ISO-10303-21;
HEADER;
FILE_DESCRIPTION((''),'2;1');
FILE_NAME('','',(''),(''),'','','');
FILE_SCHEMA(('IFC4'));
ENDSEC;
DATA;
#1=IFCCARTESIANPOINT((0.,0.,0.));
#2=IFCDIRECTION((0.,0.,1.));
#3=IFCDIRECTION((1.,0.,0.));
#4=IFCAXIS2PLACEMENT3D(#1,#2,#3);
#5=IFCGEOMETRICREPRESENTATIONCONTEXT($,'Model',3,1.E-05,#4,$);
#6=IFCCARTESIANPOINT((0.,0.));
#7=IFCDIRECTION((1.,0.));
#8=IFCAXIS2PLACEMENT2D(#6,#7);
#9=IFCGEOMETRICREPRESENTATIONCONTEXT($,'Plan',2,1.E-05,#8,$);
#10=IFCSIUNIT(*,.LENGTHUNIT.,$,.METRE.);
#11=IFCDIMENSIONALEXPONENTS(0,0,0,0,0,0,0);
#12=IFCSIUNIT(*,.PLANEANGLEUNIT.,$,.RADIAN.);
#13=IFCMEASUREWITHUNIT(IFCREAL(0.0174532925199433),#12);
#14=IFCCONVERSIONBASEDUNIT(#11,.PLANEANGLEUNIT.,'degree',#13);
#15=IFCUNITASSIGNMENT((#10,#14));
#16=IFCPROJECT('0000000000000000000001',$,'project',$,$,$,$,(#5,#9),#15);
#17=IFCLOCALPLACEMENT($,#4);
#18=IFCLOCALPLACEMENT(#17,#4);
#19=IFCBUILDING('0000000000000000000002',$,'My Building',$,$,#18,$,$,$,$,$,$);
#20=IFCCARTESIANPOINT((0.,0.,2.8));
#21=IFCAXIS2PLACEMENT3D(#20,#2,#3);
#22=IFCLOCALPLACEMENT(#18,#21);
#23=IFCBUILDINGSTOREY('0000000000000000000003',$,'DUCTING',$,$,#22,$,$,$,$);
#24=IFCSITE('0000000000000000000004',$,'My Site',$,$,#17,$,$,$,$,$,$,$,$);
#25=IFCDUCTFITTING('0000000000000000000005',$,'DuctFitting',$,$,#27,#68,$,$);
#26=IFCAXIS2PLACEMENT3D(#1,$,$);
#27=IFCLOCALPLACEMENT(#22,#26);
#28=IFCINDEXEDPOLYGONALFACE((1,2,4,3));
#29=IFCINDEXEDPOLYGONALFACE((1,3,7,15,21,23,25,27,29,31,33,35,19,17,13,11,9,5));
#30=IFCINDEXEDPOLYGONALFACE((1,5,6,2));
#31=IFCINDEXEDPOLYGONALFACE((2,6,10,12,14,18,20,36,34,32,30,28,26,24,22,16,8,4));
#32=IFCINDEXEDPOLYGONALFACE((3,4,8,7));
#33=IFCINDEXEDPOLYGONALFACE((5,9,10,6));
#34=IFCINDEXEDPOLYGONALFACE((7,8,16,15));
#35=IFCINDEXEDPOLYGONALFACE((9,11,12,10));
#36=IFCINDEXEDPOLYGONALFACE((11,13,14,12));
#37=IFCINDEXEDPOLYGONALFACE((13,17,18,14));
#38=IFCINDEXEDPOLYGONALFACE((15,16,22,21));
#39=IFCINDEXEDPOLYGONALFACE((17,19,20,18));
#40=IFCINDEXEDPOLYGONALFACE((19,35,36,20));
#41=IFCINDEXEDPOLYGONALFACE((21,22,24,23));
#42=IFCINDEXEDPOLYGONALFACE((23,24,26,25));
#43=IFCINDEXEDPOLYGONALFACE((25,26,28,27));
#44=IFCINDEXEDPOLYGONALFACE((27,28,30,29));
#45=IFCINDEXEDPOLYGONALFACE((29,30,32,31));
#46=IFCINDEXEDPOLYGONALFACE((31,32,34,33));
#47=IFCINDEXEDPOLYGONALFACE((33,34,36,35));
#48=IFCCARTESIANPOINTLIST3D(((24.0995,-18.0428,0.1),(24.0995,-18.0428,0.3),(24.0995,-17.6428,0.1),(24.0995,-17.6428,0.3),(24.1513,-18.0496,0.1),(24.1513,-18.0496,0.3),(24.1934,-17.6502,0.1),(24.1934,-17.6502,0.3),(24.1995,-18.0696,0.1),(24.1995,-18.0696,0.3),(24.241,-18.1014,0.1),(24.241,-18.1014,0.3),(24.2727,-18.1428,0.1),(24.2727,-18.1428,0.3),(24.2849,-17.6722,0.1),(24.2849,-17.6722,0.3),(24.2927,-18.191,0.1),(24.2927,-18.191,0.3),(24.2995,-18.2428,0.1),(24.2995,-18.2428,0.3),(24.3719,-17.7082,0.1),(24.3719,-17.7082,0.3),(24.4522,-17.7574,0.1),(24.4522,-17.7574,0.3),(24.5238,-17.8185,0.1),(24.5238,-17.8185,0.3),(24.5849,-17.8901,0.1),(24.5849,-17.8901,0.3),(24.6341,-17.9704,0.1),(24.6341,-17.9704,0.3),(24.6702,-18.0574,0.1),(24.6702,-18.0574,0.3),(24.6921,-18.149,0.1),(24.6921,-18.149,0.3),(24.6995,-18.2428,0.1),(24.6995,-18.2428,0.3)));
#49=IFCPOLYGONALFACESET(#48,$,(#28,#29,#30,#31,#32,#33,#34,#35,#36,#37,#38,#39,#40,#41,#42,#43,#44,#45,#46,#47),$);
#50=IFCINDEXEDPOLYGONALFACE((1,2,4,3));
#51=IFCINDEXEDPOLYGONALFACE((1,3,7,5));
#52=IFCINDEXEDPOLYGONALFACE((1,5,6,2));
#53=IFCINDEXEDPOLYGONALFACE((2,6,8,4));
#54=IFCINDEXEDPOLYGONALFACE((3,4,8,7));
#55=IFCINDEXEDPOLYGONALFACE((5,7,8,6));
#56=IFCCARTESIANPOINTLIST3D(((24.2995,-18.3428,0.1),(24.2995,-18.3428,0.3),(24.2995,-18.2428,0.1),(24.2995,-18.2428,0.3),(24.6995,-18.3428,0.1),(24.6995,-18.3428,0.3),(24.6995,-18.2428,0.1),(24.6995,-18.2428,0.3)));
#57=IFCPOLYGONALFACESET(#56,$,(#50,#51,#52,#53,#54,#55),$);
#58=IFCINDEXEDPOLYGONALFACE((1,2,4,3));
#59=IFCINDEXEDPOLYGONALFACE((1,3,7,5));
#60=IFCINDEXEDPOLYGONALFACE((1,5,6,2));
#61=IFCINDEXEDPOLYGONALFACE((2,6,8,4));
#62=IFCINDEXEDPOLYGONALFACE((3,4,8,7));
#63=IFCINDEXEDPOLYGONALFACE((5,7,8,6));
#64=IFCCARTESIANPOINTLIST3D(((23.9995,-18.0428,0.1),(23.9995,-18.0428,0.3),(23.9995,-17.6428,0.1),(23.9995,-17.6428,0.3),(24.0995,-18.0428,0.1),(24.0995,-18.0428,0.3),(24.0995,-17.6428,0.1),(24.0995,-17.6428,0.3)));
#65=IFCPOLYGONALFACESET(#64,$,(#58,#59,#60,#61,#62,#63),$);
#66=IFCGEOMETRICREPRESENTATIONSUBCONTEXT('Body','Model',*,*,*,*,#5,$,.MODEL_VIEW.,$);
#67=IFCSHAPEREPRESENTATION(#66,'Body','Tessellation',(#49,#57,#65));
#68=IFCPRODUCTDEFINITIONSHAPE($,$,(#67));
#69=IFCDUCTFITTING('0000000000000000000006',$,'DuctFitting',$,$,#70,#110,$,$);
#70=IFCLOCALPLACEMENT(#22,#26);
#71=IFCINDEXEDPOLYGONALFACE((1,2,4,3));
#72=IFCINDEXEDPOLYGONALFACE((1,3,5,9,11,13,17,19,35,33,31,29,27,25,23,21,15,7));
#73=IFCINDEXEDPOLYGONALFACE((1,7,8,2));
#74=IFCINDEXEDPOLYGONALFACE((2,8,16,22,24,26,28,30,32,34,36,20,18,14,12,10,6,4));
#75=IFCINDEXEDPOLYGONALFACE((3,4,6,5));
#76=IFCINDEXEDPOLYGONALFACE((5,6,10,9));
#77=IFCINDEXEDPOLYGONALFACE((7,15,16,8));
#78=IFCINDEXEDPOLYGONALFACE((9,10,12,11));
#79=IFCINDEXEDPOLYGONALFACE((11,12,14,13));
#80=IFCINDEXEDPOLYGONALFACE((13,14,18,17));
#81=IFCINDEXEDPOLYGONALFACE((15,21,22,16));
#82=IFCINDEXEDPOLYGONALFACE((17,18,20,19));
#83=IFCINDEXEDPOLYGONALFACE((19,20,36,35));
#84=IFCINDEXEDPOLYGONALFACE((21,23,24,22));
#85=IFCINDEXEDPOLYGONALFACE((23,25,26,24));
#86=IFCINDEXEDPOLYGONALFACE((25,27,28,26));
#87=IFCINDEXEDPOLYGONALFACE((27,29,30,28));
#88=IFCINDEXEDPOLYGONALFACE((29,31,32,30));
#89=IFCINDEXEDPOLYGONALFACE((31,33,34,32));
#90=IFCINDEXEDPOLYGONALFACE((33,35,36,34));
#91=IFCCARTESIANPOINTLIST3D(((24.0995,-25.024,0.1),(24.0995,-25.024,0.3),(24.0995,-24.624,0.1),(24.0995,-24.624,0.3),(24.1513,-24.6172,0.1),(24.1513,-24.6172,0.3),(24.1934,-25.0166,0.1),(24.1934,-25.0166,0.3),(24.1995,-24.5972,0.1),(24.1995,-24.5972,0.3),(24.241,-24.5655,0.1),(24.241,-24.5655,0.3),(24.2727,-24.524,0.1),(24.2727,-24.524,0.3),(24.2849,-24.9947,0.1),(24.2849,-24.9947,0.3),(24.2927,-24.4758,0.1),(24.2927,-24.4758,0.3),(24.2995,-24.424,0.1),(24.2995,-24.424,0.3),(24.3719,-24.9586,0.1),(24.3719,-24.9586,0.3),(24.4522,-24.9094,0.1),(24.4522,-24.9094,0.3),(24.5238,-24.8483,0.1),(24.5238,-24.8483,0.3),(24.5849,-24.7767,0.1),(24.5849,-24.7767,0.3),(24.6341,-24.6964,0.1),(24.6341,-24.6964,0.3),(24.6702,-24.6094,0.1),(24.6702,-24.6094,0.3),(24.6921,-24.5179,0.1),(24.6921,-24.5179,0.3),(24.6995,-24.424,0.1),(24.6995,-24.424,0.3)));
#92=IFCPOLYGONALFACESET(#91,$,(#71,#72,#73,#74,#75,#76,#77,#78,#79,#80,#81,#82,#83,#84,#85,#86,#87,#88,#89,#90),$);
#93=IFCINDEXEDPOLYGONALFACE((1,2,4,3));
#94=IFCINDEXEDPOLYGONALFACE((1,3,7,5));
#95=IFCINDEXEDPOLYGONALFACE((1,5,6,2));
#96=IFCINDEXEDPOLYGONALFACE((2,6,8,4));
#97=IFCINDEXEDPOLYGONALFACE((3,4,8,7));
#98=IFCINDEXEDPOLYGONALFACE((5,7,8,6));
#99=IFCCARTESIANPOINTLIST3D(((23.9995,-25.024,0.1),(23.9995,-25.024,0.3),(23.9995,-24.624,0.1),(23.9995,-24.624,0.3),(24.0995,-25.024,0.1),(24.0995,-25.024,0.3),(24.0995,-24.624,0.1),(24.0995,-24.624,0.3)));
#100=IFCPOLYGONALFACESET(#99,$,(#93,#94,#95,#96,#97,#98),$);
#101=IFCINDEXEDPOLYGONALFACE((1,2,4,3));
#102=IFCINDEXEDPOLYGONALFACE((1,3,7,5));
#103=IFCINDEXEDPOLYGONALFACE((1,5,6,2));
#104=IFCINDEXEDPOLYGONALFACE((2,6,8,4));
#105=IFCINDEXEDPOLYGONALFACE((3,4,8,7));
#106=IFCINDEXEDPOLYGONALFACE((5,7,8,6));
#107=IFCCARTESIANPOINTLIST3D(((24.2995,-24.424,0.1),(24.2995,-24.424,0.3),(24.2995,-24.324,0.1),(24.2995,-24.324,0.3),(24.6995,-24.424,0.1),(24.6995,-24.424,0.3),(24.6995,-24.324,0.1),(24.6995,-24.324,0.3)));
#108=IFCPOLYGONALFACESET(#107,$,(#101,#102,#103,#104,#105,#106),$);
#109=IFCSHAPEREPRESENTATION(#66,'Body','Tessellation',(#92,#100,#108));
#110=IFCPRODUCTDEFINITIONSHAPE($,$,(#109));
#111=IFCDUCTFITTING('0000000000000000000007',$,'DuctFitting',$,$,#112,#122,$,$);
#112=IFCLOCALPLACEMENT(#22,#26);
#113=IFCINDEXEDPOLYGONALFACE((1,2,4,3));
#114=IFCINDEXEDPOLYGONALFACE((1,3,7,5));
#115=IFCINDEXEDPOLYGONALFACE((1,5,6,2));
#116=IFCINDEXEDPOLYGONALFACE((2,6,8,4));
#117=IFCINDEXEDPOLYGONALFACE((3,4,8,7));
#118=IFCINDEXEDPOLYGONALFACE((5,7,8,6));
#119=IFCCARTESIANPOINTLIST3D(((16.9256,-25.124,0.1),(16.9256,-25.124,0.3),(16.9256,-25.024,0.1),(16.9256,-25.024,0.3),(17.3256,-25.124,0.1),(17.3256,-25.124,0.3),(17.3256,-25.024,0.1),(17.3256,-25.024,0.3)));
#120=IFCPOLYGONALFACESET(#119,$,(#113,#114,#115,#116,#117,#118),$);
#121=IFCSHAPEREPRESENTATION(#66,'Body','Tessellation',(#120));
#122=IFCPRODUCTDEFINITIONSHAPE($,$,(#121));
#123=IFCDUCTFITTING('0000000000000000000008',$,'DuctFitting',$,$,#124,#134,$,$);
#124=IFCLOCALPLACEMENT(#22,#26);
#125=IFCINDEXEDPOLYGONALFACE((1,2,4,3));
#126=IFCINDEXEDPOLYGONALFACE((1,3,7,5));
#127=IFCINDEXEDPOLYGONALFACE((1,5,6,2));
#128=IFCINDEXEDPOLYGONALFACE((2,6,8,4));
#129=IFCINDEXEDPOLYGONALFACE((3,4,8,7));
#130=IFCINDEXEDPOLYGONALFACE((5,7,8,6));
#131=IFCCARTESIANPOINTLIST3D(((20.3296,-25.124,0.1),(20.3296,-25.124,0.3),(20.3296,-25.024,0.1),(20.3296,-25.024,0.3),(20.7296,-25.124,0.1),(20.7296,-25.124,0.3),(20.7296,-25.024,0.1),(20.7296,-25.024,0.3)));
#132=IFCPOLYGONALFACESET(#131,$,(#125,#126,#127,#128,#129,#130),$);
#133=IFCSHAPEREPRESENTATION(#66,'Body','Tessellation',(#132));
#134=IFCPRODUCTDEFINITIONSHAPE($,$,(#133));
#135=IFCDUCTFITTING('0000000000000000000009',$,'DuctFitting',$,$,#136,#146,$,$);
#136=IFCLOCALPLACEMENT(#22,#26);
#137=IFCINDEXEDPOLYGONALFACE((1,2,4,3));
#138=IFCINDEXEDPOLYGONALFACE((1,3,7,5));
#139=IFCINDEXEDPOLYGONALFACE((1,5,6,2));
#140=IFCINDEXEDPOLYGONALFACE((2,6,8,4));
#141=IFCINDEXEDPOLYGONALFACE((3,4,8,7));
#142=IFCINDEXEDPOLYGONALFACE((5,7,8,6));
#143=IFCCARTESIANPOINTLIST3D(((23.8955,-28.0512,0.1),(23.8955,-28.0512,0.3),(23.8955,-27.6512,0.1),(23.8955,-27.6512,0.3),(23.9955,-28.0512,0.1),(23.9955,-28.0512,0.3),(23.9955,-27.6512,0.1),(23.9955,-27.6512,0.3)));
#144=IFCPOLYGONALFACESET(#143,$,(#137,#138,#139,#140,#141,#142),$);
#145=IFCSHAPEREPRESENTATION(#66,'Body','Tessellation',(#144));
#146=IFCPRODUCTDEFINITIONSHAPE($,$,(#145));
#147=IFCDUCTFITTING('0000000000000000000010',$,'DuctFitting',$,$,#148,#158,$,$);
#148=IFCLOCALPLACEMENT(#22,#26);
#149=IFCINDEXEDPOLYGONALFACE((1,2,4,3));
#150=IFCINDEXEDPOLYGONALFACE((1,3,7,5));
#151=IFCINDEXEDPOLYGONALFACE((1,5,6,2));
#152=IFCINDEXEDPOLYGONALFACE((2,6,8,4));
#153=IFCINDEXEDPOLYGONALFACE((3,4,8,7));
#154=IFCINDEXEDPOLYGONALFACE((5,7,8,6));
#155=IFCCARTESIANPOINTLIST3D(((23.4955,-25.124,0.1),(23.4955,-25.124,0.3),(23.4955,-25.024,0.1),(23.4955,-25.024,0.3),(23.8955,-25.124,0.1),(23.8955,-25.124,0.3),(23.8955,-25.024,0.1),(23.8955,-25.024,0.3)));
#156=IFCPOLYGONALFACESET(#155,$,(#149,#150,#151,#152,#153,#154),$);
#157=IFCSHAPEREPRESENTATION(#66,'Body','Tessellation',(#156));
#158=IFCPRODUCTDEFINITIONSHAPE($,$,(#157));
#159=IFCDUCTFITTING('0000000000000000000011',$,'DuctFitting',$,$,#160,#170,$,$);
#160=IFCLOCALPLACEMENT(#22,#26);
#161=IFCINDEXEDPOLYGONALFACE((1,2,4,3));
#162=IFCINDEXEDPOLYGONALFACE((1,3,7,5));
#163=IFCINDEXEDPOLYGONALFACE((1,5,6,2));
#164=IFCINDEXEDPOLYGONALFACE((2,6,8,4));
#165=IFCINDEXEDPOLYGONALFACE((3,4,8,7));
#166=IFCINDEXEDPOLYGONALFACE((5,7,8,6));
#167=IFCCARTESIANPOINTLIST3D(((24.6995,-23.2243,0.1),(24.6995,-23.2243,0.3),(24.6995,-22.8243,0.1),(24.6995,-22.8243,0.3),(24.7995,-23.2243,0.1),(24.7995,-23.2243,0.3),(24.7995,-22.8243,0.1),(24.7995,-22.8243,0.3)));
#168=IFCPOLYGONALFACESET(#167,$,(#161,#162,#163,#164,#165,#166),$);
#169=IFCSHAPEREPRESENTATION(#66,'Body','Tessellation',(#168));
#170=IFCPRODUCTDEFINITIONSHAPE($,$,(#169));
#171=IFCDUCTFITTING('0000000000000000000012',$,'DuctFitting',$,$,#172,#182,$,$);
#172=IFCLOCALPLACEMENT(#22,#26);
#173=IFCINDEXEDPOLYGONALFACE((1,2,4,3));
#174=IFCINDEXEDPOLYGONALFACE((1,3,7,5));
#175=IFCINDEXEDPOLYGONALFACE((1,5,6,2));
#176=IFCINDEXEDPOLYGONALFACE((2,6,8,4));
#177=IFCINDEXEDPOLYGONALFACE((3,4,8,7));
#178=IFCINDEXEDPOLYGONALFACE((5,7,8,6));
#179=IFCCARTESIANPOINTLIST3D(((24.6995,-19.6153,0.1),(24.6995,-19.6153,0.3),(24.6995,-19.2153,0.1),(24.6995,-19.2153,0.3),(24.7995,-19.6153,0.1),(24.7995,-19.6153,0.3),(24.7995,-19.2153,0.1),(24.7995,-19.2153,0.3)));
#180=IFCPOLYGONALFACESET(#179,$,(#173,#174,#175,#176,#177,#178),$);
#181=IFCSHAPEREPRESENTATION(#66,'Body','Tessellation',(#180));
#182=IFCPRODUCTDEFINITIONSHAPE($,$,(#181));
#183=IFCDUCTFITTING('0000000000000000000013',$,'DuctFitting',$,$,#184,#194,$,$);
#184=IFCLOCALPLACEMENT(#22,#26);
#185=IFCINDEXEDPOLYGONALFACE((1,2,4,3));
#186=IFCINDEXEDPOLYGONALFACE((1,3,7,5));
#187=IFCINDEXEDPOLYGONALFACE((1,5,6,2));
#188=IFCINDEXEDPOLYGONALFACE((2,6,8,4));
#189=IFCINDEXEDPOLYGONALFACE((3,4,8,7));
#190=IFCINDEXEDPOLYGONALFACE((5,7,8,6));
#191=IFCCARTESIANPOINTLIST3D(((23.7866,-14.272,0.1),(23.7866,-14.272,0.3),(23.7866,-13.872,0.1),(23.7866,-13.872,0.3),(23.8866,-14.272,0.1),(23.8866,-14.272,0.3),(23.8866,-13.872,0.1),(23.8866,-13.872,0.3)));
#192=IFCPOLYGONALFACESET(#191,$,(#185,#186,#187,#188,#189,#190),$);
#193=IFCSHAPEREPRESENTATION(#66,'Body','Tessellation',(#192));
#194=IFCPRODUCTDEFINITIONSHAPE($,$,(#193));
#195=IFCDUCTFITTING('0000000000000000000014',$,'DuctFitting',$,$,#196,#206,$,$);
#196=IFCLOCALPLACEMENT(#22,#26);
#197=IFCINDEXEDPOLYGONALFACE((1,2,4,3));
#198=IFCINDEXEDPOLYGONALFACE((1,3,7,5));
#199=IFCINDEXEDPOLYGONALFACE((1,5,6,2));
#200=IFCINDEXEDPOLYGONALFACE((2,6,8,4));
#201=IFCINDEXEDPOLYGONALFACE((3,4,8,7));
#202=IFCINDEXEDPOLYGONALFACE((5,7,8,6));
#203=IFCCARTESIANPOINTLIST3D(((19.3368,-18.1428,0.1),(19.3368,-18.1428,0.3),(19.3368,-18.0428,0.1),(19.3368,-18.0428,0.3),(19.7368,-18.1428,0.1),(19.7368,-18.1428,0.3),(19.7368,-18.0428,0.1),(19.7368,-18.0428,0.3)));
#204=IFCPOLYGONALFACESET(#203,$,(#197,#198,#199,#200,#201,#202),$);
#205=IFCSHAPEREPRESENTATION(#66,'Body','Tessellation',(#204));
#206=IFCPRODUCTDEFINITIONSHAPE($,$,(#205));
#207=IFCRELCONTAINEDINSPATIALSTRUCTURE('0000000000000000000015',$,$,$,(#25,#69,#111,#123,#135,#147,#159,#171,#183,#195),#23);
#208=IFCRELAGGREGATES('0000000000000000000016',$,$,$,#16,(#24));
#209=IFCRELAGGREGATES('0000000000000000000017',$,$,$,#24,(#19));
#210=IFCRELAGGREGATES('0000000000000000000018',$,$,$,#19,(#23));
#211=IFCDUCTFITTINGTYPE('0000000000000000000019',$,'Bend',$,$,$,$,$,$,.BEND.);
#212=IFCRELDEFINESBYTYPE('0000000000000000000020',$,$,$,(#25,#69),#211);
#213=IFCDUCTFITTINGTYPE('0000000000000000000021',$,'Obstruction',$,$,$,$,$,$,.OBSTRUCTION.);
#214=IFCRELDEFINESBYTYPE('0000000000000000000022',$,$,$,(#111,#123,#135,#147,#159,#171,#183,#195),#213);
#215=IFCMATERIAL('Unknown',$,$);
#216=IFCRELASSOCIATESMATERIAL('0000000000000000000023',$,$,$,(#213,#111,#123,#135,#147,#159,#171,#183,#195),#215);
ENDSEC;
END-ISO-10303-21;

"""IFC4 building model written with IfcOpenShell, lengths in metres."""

from ifc_helpers import new_model, entity, si_unit, converted_unit, frame, origin_with_axes, origin_2d_with_axis, place, context, subcontext, project, spatial, line, arc, indexed_curve, rectangle, outline, extrude, source, transform, mapped, material, material_profile, profile_set, profile_usage, type_object, type_shapes, element, save


model = new_model("IFC4")

# Units and contexts
model_context = context("Model", 3, precision=1e-05, world=origin_with_axes())
plan_context = context("Plan", 2, precision=1e-05, world=origin_2d_with_axis())
body_context = subcontext(model_context, "Body", "Model", "MODEL_VIEW")
ifc_project = project(units=[si_unit("LENGTHUNIT", "METRE"), converted_unit("PLANEANGLEUNIT", "degree", entity("IfcReal", 0.0174532925199433), si_unit("PLANEANGLEUNIT", "RADIAN"), dimensions=[0, 0, 0, 0, 0, 0, 0])], contexts=[model_context, plan_context])

# Site, building, storey
site_placement = place(None, origin_with_axes())
site = spatial("IfcSite", under=ifc_project, at=site_placement, Name="My Site")
building_placement = place(site_placement, origin_with_axes())
building = spatial("IfcBuilding", under=site, at=building_placement, Name="My Building")
storey_placement = place(building_placement, frame((0.0, 0.0, 2.8), z_axis=(0.0, 0.0, 1.0), x_axis=(1.0, 0.0, 0.0)))
storey = spatial("IfcBuildingStorey", under=building, at=storey_placement, Name="DUCTING")

# Shared definitions
ifc_material = material(Name="Unknown")

# Duct fittings
duct_fitting_type_1 = type_object("IfcDuctFittingType", Name="Bend", PredefinedType="BEND")
shared_shape = source(origin_with_axes(), body_context, "Body", "SweptSolid", [
    extrude(outline(indexed_curve([(0.2, 0.0), (0.2586, 0.1414), (0.4, 0.2), (0.4, 0.6), (-0.0243, 0.4243), (-0.2, 0.0)], segments=[arc(1, 2, 3), line(3, 4), arc(4, 5, 6), line(6, 1)])), frame((0.0, -0.1, 0.1), z_axis=(0.0, -1.0, 0.0), x_axis=(1.0, 0.0, 0.0)), (0.0, 0.0, -1.0), 0.2),
    extrude(rectangle(XDim=0.4, YDim=0.2), origin_with_axes(), (0.0, 0.0, 1.0), 0.1),
    extrude(rectangle(XDim=0.4, YDim=0.2), frame((0.4, 0.0, 0.5), z_axis=(1.0, 0.0, 0.0), x_axis=(0.0, 0.0, 1.0)), (0.0, 0.0, 1.0), 0.1),
])
type_shapes(duct_fitting_type_1, [shared_shape])
for number, where, z_axis, x_axis, name in (
    (1, (24.4995, -18.3428, 0.2), (0.0, 1.0, 0.0), (-1.0, 0.0, 0.0), "DuctFitting"),
    (2, (23.9995, -24.824, 0.2), (1.0, 0.0, 0.0), (0.0, 1.0, 0.0), "DuctFitting"),
):
    element("IfcDuctFitting", number, at=place(storey_placement, frame(where, z_axis=z_axis, x_axis=x_axis)), inside=storey, type_object=duct_fitting_type_1, Name=name, context=body_context, shape_type="MappedRepresentation", body=[
        mapped(shared_shape, transform((0.0, 0.0, 0.0), x_axis=(1.0, 0.0, 0.0), y_axis=(0.0, 1.0, 0.0), z_axis=(0.0, 0.0, 1.0), scale=1.0)),
    ])
ifc_material_profile_1 = material_profile(ifc_material, rectangle(XDim=0.4, YDim=0.2))
ifc_profile_set_1 = profile_set([ifc_material_profile_1])
ifc_profile_usage_1 = profile_usage(ifc_profile_set_1, cardinal=5)
duct_fitting_type_2 = type_object("IfcDuctFittingType", Name="Obstruction", PredefinedType="OBSTRUCTION", material=ifc_profile_set_1)
duct_fitting_1_placement = place(storey_placement, frame((17.1256, -25.024, 0.2), z_axis=(0.0, -1.0, 0.0), x_axis=(1.0, 0.0, 0.0)))
element("IfcDuctFitting", 3, at=duct_fitting_1_placement, inside=storey, type_object=duct_fitting_type_2, material=ifc_profile_usage_1, Name="DuctFitting", context=body_context, shape_type="SweptSolid", body=[
    extrude(rectangle(XDim=0.4, YDim=0.2), origin_with_axes(), (0.0, 0.0, 1.0), 0.1),
])
ifc_profile_usage_2 = profile_usage(ifc_profile_set_1, cardinal=5)
duct_fitting_2_placement = place(storey_placement, frame((20.5296, -25.024, 0.2), z_axis=(0.0, -1.0, 0.0), x_axis=(1.0, 0.0, 0.0)))
element("IfcDuctFitting", 4, at=duct_fitting_2_placement, inside=storey, type_object=duct_fitting_type_2, material=ifc_profile_usage_2, Name="DuctFitting", context=body_context, shape_type="SweptSolid", body=[
    extrude(rectangle(XDim=0.4, YDim=0.2), origin_with_axes(), (0.0, 0.0, 1.0), 0.1),
])
ifc_profile_usage_3 = profile_usage(ifc_profile_set_1, cardinal=5)
duct_fitting_3_placement = place(storey_placement, frame((23.8955, -27.8512, 0.2), z_axis=(1.0, 0.0, 0.0), x_axis=(0.0, 1.0, 0.0)))
element("IfcDuctFitting", 5, at=duct_fitting_3_placement, inside=storey, type_object=duct_fitting_type_2, material=ifc_profile_usage_3, Name="DuctFitting", context=body_context, shape_type="SweptSolid", body=[
    extrude(rectangle(XDim=0.4, YDim=0.2), origin_with_axes(), (0.0, 0.0, 1.0), 0.1),
])
ifc_profile_usage_4 = profile_usage(ifc_profile_set_1, cardinal=5)
duct_fitting_4_placement = place(storey_placement, frame((23.6955, -25.024, 0.2), z_axis=(0.0, -1.0, 0.0), x_axis=(1.0, 0.0, 0.0)))
element("IfcDuctFitting", 6, at=duct_fitting_4_placement, inside=storey, type_object=duct_fitting_type_2, material=ifc_profile_usage_4, Name="DuctFitting", context=body_context, shape_type="SweptSolid", body=[
    extrude(rectangle(XDim=0.4, YDim=0.2), origin_with_axes(), (0.0, 0.0, 1.0), 0.1),
])
ifc_profile_usage_5 = profile_usage(ifc_profile_set_1, cardinal=5)
duct_fitting_5_placement = place(storey_placement, frame((24.6995, -23.0243, 0.2), z_axis=(1.0, 0.0, 0.0), x_axis=(0.0, 1.0, 0.0)))
element("IfcDuctFitting", 7, at=duct_fitting_5_placement, inside=storey, type_object=duct_fitting_type_2, material=ifc_profile_usage_5, Name="DuctFitting", context=body_context, shape_type="SweptSolid", body=[
    extrude(rectangle(XDim=0.4, YDim=0.2), origin_with_axes(), (0.0, 0.0, 1.0), 0.1),
])
ifc_profile_usage_6 = profile_usage(ifc_profile_set_1, cardinal=5)
duct_fitting_6_placement = place(storey_placement, frame((24.6995, -19.4153, 0.2), z_axis=(1.0, 0.0, 0.0), x_axis=(0.0, 1.0, 0.0)))
element("IfcDuctFitting", 8, at=duct_fitting_6_placement, inside=storey, type_object=duct_fitting_type_2, material=ifc_profile_usage_6, Name="DuctFitting", context=body_context, shape_type="SweptSolid", body=[
    extrude(rectangle(XDim=0.4, YDim=0.2), origin_with_axes(), (0.0, 0.0, 1.0), 0.1),
])
ifc_profile_usage_7 = profile_usage(ifc_profile_set_1, cardinal=5)
duct_fitting_7_placement = place(storey_placement, frame((23.7866, -14.072, 0.2), z_axis=(1.0, 0.0, 0.0), x_axis=(0.0, 1.0, 0.0)))
element("IfcDuctFitting", 9, at=duct_fitting_7_placement, inside=storey, type_object=duct_fitting_type_2, material=ifc_profile_usage_7, Name="DuctFitting", context=body_context, shape_type="SweptSolid", body=[
    extrude(rectangle(XDim=0.4, YDim=0.2), origin_with_axes(), (0.0, 0.0, 1.0), 0.1),
])
ifc_profile_usage_8 = profile_usage(ifc_profile_set_1, cardinal=5)
duct_fitting_8_placement = place(storey_placement, frame((19.5368, -18.0428, 0.2), z_axis=(0.0, -1.0, 0.0), x_axis=(1.0, 0.0, 0.0)))
element("IfcDuctFitting", 10, at=duct_fitting_8_placement, inside=storey, type_object=duct_fitting_type_2, material=ifc_profile_usage_8, Name="DuctFitting", context=body_context, shape_type="SweptSolid", body=[
    extrude(rectangle(XDim=0.4, YDim=0.2), origin_with_axes(), (0.0, 0.0, 1.0), 0.1),
])

save(model, "model.ifc")
